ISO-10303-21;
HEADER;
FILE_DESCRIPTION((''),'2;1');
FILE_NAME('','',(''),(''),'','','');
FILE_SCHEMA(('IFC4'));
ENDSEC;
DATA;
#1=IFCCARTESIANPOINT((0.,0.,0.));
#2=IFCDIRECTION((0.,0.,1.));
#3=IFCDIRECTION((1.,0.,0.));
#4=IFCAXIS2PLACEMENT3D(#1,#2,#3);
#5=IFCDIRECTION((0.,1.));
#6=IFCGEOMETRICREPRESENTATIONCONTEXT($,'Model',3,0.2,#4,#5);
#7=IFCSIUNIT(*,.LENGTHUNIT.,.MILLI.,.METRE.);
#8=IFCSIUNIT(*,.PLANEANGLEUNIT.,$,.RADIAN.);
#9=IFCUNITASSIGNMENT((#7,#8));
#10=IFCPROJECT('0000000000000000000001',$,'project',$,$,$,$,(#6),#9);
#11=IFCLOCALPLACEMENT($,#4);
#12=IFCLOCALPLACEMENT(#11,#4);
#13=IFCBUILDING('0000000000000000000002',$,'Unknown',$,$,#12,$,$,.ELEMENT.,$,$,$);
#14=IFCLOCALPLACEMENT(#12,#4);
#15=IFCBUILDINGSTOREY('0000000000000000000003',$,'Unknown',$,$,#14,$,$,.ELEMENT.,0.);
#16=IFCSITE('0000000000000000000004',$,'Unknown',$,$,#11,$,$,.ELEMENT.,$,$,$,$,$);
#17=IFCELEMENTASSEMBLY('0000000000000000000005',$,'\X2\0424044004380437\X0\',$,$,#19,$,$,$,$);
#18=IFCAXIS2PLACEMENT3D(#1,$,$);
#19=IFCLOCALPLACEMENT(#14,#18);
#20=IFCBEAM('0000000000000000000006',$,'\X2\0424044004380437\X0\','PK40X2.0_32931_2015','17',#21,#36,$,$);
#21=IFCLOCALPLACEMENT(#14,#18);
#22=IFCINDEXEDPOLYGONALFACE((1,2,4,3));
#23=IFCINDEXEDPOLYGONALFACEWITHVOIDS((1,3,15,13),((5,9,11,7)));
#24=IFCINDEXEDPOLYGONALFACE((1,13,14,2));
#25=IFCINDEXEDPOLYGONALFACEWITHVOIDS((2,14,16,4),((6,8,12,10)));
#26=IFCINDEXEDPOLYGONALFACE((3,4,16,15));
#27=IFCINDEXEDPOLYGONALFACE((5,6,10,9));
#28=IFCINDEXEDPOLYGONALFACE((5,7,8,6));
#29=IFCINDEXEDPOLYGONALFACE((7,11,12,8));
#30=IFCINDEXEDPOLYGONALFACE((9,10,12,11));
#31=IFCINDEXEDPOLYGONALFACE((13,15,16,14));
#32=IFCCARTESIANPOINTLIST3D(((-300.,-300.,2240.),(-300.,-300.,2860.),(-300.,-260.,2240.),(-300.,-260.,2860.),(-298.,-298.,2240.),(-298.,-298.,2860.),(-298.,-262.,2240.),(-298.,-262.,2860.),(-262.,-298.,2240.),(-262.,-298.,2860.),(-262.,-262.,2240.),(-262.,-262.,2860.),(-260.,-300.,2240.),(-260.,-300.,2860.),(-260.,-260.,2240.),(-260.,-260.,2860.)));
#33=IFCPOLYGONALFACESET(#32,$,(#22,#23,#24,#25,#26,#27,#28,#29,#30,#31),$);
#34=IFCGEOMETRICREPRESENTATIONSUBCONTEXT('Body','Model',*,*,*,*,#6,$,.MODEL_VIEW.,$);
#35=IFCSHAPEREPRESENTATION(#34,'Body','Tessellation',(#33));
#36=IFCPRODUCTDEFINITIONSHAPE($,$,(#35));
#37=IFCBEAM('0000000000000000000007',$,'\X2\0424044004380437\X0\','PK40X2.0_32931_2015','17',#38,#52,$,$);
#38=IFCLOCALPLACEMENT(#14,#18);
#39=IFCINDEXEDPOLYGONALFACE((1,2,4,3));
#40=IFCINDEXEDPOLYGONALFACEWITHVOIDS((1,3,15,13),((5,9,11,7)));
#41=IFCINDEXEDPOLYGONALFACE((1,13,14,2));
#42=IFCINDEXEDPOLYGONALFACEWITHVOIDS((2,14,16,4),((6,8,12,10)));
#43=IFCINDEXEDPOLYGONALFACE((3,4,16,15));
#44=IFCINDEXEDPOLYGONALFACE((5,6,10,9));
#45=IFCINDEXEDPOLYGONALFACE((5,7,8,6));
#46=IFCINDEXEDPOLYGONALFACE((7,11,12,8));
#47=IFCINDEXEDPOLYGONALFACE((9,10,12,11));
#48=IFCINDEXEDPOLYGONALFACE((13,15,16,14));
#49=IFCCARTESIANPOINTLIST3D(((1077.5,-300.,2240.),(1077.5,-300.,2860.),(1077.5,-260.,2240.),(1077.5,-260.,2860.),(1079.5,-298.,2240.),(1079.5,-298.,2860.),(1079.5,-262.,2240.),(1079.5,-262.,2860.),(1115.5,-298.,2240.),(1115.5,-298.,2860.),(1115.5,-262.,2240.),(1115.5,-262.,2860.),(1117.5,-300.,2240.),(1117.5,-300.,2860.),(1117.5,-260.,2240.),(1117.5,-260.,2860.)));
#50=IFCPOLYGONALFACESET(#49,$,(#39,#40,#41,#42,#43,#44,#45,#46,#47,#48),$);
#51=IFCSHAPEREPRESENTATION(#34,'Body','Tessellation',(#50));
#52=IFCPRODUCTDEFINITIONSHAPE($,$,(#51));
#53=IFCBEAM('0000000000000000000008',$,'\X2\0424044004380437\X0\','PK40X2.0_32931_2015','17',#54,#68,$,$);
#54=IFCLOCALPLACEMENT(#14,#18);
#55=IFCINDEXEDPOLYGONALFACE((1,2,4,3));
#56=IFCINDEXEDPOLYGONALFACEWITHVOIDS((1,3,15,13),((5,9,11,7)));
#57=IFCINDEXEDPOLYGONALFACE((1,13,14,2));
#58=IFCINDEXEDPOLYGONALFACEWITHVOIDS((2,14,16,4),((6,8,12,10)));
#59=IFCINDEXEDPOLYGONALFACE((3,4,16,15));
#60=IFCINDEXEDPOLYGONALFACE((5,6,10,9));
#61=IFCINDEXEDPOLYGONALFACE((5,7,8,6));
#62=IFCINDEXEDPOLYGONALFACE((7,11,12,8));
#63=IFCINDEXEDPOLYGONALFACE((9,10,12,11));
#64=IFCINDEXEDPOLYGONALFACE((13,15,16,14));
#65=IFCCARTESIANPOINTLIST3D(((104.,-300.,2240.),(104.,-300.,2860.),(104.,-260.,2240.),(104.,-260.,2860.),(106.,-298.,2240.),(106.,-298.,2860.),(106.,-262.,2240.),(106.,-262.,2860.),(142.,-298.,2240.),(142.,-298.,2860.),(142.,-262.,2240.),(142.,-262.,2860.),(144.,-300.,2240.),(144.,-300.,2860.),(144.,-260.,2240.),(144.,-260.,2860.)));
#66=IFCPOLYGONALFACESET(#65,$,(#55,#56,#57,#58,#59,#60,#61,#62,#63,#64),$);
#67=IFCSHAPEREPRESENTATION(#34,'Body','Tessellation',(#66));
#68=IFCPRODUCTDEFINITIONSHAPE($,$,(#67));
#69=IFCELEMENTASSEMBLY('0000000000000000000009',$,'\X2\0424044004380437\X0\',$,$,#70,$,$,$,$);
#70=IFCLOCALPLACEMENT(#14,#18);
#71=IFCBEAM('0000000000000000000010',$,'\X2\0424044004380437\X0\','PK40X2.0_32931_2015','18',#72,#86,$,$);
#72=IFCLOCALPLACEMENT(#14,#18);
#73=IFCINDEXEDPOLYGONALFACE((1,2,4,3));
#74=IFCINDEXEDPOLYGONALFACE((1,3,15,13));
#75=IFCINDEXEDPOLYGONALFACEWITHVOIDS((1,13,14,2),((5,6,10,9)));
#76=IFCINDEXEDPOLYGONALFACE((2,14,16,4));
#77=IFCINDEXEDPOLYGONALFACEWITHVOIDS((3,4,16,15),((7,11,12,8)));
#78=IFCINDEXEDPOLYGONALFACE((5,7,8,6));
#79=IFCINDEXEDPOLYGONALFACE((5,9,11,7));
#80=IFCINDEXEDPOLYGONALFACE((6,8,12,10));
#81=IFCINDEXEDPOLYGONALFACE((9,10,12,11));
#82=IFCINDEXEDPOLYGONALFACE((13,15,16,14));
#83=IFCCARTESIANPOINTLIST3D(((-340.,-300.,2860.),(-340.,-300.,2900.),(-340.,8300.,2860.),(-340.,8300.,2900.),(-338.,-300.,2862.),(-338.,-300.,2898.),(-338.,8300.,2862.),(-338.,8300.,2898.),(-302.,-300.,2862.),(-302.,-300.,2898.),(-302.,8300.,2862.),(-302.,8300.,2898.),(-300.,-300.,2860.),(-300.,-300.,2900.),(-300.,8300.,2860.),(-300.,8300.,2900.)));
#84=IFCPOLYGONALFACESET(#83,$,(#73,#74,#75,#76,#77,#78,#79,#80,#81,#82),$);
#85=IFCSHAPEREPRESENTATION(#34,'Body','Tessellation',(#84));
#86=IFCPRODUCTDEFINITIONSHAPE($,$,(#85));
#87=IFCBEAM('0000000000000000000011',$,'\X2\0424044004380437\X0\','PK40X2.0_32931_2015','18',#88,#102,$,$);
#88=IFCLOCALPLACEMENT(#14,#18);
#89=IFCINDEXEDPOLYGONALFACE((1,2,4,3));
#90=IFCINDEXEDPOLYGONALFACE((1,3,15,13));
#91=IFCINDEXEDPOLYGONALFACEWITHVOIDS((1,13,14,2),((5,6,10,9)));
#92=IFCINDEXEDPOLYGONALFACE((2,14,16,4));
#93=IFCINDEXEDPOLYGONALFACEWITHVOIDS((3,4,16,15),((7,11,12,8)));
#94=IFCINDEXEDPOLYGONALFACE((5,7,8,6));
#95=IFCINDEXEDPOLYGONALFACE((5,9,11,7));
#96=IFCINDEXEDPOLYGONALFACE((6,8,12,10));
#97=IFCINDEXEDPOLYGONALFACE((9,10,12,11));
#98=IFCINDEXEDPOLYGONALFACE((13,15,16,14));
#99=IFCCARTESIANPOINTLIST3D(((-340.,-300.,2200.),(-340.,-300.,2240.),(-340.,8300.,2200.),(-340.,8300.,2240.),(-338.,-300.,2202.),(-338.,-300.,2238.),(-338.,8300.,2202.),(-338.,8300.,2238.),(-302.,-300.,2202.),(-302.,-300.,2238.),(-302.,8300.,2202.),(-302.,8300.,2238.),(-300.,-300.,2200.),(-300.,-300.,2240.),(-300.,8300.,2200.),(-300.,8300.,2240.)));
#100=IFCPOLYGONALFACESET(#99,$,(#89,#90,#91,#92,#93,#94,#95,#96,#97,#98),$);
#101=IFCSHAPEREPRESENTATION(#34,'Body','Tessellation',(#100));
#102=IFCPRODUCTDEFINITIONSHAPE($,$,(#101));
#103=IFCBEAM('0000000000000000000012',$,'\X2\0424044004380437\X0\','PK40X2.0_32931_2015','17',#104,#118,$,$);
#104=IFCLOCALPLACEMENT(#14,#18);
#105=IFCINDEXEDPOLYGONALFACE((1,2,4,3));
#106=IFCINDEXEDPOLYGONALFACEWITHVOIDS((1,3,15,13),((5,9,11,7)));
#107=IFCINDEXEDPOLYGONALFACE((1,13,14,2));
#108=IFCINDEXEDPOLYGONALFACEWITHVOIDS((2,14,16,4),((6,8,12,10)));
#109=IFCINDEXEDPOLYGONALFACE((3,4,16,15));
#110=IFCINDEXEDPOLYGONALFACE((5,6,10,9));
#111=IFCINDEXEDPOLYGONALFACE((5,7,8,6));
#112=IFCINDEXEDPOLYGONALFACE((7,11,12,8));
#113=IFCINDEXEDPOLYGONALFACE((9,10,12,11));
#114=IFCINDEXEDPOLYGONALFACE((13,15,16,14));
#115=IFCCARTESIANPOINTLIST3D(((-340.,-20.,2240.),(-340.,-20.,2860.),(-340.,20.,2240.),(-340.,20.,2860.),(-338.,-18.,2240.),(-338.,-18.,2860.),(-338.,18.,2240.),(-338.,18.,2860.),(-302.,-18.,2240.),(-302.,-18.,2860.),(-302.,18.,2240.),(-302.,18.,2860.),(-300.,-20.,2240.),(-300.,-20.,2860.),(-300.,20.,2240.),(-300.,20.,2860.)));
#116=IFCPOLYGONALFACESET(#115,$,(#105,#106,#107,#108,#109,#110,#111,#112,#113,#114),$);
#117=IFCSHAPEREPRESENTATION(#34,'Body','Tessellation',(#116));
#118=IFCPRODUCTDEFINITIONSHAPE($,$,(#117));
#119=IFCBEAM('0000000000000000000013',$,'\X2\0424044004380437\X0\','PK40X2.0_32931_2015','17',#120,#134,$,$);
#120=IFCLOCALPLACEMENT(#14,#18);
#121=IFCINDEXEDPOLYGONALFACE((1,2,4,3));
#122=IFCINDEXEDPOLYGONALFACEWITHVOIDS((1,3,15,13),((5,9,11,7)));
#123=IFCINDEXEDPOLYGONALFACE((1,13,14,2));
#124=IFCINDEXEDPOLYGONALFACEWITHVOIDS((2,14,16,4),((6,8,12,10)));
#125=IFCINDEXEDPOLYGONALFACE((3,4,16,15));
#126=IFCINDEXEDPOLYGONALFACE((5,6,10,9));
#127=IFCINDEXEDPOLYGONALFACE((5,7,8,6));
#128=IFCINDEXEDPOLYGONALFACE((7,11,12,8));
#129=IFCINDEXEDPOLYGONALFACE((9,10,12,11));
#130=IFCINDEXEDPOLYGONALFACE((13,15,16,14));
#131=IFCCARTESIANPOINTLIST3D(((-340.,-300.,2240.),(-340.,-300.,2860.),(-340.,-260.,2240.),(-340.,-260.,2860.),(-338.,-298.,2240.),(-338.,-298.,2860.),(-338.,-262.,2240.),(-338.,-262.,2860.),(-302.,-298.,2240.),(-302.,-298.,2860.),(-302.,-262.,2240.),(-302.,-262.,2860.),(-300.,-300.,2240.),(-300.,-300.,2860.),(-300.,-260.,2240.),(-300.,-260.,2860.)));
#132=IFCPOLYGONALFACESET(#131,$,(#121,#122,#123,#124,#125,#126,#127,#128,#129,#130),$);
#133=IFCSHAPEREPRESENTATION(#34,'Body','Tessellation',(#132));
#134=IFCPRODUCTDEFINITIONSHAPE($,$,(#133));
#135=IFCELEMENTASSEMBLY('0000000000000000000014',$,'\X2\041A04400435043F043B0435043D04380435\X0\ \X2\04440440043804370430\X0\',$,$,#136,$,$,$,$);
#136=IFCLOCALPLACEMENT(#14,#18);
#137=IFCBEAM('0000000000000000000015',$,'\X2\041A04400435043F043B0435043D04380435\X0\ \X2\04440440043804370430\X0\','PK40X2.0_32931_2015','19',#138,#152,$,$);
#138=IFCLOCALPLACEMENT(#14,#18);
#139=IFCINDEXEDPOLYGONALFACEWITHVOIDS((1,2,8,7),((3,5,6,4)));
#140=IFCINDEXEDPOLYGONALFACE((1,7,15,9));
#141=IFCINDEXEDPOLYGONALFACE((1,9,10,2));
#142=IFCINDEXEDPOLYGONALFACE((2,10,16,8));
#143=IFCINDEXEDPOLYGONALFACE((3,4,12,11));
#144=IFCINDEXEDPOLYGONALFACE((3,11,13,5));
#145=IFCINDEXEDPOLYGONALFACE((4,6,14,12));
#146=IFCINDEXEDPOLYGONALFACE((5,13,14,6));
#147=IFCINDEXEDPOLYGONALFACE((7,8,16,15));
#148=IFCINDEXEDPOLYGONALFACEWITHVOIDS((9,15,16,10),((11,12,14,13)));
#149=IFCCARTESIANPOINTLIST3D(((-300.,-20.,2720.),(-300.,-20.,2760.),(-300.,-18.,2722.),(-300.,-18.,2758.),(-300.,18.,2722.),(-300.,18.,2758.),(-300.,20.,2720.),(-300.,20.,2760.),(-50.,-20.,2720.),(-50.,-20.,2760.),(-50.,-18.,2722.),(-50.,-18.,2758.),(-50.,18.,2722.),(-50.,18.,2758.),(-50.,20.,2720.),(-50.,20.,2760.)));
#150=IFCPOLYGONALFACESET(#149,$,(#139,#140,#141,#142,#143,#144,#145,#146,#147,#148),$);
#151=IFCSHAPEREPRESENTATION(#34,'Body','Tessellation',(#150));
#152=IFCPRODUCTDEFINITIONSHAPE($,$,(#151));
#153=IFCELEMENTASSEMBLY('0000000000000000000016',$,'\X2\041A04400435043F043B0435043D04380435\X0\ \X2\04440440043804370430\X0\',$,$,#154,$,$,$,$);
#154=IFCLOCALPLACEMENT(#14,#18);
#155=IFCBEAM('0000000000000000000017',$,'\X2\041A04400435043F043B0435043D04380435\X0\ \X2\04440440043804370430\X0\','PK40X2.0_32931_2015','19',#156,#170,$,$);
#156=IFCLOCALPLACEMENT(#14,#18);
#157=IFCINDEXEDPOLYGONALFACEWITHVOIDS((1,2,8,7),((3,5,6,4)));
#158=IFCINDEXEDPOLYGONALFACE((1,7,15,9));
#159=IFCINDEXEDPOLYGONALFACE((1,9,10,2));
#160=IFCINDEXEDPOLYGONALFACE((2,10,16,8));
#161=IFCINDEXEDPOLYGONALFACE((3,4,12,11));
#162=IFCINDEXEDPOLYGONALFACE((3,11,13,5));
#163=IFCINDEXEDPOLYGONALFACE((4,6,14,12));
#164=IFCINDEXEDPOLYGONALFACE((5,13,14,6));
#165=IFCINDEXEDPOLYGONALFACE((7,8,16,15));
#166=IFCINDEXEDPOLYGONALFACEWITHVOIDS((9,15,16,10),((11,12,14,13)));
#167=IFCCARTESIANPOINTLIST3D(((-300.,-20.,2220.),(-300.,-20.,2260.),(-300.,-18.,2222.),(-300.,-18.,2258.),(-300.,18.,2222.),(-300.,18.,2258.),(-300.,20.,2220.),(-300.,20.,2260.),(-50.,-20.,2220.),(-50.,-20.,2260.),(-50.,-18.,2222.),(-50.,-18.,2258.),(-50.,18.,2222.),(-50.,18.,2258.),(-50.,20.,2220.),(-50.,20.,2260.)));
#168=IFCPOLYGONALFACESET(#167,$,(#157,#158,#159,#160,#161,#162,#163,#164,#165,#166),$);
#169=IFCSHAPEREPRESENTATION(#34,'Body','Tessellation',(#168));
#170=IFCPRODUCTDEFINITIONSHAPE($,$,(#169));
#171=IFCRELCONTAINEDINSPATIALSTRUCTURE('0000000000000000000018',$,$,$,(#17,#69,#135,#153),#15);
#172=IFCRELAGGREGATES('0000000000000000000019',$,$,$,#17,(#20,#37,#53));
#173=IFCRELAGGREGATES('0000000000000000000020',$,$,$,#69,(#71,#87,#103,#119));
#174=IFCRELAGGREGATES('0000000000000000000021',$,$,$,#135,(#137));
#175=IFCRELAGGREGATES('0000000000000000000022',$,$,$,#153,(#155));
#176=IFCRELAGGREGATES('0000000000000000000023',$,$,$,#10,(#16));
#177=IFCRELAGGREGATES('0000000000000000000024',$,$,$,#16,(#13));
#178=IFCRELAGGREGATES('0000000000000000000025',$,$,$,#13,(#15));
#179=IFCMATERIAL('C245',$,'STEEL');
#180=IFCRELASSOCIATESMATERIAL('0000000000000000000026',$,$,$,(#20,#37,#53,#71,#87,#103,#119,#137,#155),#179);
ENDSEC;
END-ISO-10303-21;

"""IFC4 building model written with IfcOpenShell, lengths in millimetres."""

from ifc_helpers import new_model, si_unit, direction, frame, origin_with_axes, place, context, subcontext, project, spatial, line, indexed_curve, outline, extrude, material, element, aggregate, save


model = new_model("IFC4")

# Units and contexts
model_context = context("Model", 3, precision=0.2, world=origin_with_axes(), true_north=direction((0.0, 1.0)))
body_context = subcontext(model_context, "Body", "Model", "MODEL_VIEW")
ifc_project = project(units=[si_unit("LENGTHUNIT", "METRE", prefix="MILLI"), si_unit("PLANEANGLEUNIT", "RADIAN")], contexts=[model_context])

# Site, building, storey
site_placement = place(None, origin_with_axes())
site = spatial("IfcSite", under=ifc_project, at=site_placement, Name="Unknown", CompositionType="ELEMENT")
building_placement = place(site_placement, origin_with_axes())
building = spatial("IfcBuilding", under=site, at=building_placement, Name="Unknown", CompositionType="ELEMENT")
storey_placement = place(building_placement, origin_with_axes())
storey = spatial("IfcBuildingStorey", under=building, at=storey_placement, Name="Unknown", CompositionType="ELEMENT", Elevation=0.0)

# Shared definitions
ifc_material_1 = material(Name="C245", Category="STEEL")

# Element assemblies, beams
assembly_1_placement = place(storey_placement, frame((-300.0, -280.0, 2880.0), z_axis=(0.0, -1.0, 0.0), x_axis=(1.0, 0.0, 0.0)))
assembly_1 = element("IfcElementAssembly", 1, at=assembly_1_placement, inside=storey, Name="Фриз")
beam_1_placement = place(assembly_1_placement, frame((20.0, -20.0, 0.0), z_axis=(0.0, 0.0, -1.0), x_axis=(0.0, -1.0, 0.0)))
beam_1 = element("IfcBeam", 2, at=beam_1_placement, material=ifc_material_1, Name="Фриз", Description="PK40X2.0_32931_2015", ObjectType="17", context=body_context, shape_type="SolidModel", body=[
    extrude(outline(indexed_curve([(-20.0, -20.0), (20.0, -20.0), (20.0, 20.0), (-20.0, 20.0)], segments=[line(1, 2, 3, 4, 1)]), holes=[indexed_curve([(-18.0, -18.0), (-18.0, 18.0), (18.0, 18.0), (18.0, -18.0)], segments=[line(1, 2, 3, 4, 1)])]), frame((0.0, 0.0, 0.0), z_axis=(-1.0, 0.0, 0.0), x_axis=(0.0, 0.0, 1.0)), (0.0, 0.0, -1.0), 620.0),
])
beam_2_placement = place(assembly_1_placement, frame((1397.5, -20.0, 0.0), z_axis=(0.0, 0.0, 1.0), x_axis=(0.0, -1.0, 0.0)))
beam_2 = element("IfcBeam", 3, at=beam_2_placement, material=ifc_material_1, Name="Фриз", Description="PK40X2.0_32931_2015", ObjectType="17", context=body_context, shape_type="SolidModel", body=[
    extrude(outline(indexed_curve([(-20.0, -20.0), (20.0, -20.0), (20.0, 20.0), (-20.0, 20.0)], segments=[line(1, 2, 3, 4, 1)]), holes=[indexed_curve([(-18.0, -18.0), (-18.0, 18.0), (18.0, 18.0), (18.0, -18.0)], segments=[line(1, 2, 3, 4, 1)])]), frame((0.0, 0.0, 0.0), z_axis=(-1.0, 0.0, 0.0), x_axis=(0.0, 0.0, 1.0)), (0.0, 0.0, -1.0), 620.0),
])
beam_3_placement = place(assembly_1_placement, frame((424.0, -20.0, 0.0), z_axis=(0.0, 0.0, 1.0), x_axis=(0.0, -1.0, 0.0)))
beam_3 = element("IfcBeam", 4, at=beam_3_placement, material=ifc_material_1, Name="Фриз", Description="PK40X2.0_32931_2015", ObjectType="17", context=body_context, shape_type="SolidModel", body=[
    extrude(outline(indexed_curve([(-20.0, -20.0), (20.0, -20.0), (20.0, 20.0), (-20.0, 20.0)], segments=[line(1, 2, 3, 4, 1)]), holes=[indexed_curve([(-18.0, -18.0), (-18.0, 18.0), (18.0, 18.0), (18.0, -18.0)], segments=[line(1, 2, 3, 4, 1)])]), frame((0.0, 0.0, 0.0), z_axis=(-1.0, 0.0, 0.0), x_axis=(0.0, 0.0, 1.0)), (0.0, 0.0, -1.0), 620.0),
])
aggregate(assembly_1, [beam_1, beam_2, beam_3])
assembly_2_placement = place(storey_placement, frame((-320.0, -300.0, 2880.0), z_axis=(1.0, 0.0, 0.0), x_axis=(0.0, 1.0, 0.0)))
assembly_2 = element("IfcElementAssembly", 5, at=assembly_2_placement, inside=storey, Name="Фриз")
beam_4_placement = place(assembly_2_placement, origin_with_axes())
beam_4 = element("IfcBeam", 6, at=beam_4_placement, material=ifc_material_1, Name="Фриз", Description="PK40X2.0_32931_2015", ObjectType="18", context=body_context, shape_type="SolidModel", body=[
    extrude(outline(indexed_curve([(-20.0, -20.0), (20.0, -20.0), (20.0, 20.0), (-20.0, 20.0)], segments=[line(1, 2, 3, 4, 1)]), holes=[indexed_curve([(-18.0, -18.0), (-18.0, 18.0), (18.0, 18.0), (18.0, -18.0)], segments=[line(1, 2, 3, 4, 1)])]), frame((0.0, 0.0, 0.0), z_axis=(-1.0, 0.0, 0.0), x_axis=(0.0, 0.0, 1.0)), (0.0, 0.0, -1.0), 8600.0),
])
beam_5_placement = place(assembly_2_placement, frame((0.0, -660.0, 0.0), z_axis=(0.0, 0.0, 1.0), x_axis=(1.0, 0.0, 0.0)))
beam_5 = element("IfcBeam", 7, at=beam_5_placement, material=ifc_material_1, Name="Фриз", Description="PK40X2.0_32931_2015", ObjectType="18", context=body_context, shape_type="SolidModel", body=[
    extrude(outline(indexed_curve([(-20.0, -20.0), (20.0, -20.0), (20.0, 20.0), (-20.0, 20.0)], segments=[line(1, 2, 3, 4, 1)]), holes=[indexed_curve([(-18.0, -18.0), (-18.0, 18.0), (18.0, 18.0), (18.0, -18.0)], segments=[line(1, 2, 3, 4, 1)])]), frame((0.0, 0.0, 0.0), z_axis=(-1.0, 0.0, 0.0), x_axis=(0.0, 0.0, 1.0)), (0.0, 0.0, -1.0), 8600.0),
])
beam_6_placement = place(assembly_2_placement, frame((300.0, -20.0, 0.0), z_axis=(-1.0, 0.0, 0.0), x_axis=(0.0, -1.0, 0.0)))
beam_6 = element("IfcBeam", 8, at=beam_6_placement, material=ifc_material_1, Name="Фриз", Description="PK40X2.0_32931_2015", ObjectType="17", context=body_context, shape_type="SolidModel", body=[
    extrude(outline(indexed_curve([(-20.0, -20.0), (20.0, -20.0), (20.0, 20.0), (-20.0, 20.0)], segments=[line(1, 2, 3, 4, 1)]), holes=[indexed_curve([(-18.0, -18.0), (-18.0, 18.0), (18.0, 18.0), (18.0, -18.0)], segments=[line(1, 2, 3, 4, 1)])]), frame((0.0, 0.0, 0.0), z_axis=(-1.0, 0.0, 0.0), x_axis=(0.0, 0.0, 1.0)), (0.0, 0.0, -1.0), 620.0),
])
beam_7_placement = place(assembly_2_placement, frame((20.0, -20.0, 0.0), z_axis=(-1.0, 0.0, 0.0), x_axis=(0.0, -1.0, 0.0)))
beam_7 = element("IfcBeam", 9, at=beam_7_placement, material=ifc_material_1, Name="Фриз", Description="PK40X2.0_32931_2015", ObjectType="17", context=body_context, shape_type="SolidModel", body=[
    extrude(outline(indexed_curve([(-20.0, -20.0), (20.0, -20.0), (20.0, 20.0), (-20.0, 20.0)], segments=[line(1, 2, 3, 4, 1)]), holes=[indexed_curve([(-18.0, -18.0), (-18.0, 18.0), (18.0, 18.0), (18.0, -18.0)], segments=[line(1, 2, 3, 4, 1)])]), frame((0.0, 0.0, 0.0), z_axis=(-1.0, 0.0, 0.0), x_axis=(0.0, 0.0, 1.0)), (0.0, 0.0, -1.0), 620.0),
])
aggregate(assembly_2, [beam_4, beam_5, beam_6, beam_7])

# Element assemblies, beams
assembly_3_placement = place(storey_placement, frame((-300.0, 0.0, 2740.0), z_axis=(0.0, 1.0, 0.0), x_axis=(1.0, 0.0, 0.0)))
assembly_3 = element("IfcElementAssembly", 10, at=assembly_3_placement, inside=storey, Name="Крепление фриза")
beam_8_placement = place(assembly_3_placement, origin_with_axes())
beam_8 = element("IfcBeam", 11, at=beam_8_placement, material=ifc_material_1, Name="Крепление фриза", Description="PK40X2.0_32931_2015", ObjectType="19", context=body_context, shape_type="SolidModel", body=[
    extrude(outline(indexed_curve([(-20.0, -20.0), (20.0, -20.0), (20.0, 20.0), (-20.0, 20.0)], segments=[line(1, 2, 3, 4, 1)]), holes=[indexed_curve([(-18.0, -18.0), (-18.0, 18.0), (18.0, 18.0), (18.0, -18.0)], segments=[line(1, 2, 3, 4, 1)])]), frame((0.0, 0.0, 0.0), z_axis=(-1.0, 0.0, 0.0), x_axis=(0.0, 0.0, 1.0)), (0.0, 0.0, -1.0), 250.0),
])
aggregate(assembly_3, [beam_8])
assembly_4_placement = place(storey_placement, frame((-300.0, 0.0, 2240.0), z_axis=(0.0, 1.0, 0.0), x_axis=(1.0, 0.0, 0.0)))
assembly_4 = element("IfcElementAssembly", 12, at=assembly_4_placement, inside=storey, Name="Крепление фриза")
beam_9_placement = place(assembly_4_placement, origin_with_axes())
beam_9 = element("IfcBeam", 13, at=beam_9_placement, material=ifc_material_1, Name="Крепление фриза", Description="PK40X2.0_32931_2015", ObjectType="19", context=body_context, shape_type="SolidModel", body=[
    extrude(outline(indexed_curve([(-20.0, -20.0), (20.0, -20.0), (20.0, 20.0), (-20.0, 20.0)], segments=[line(1, 2, 3, 4, 1)]), holes=[indexed_curve([(-18.0, -18.0), (-18.0, 18.0), (18.0, 18.0), (18.0, -18.0)], segments=[line(1, 2, 3, 4, 1)])]), frame((0.0, 0.0, 0.0), z_axis=(-1.0, 0.0, 0.0), x_axis=(0.0, 0.0, 1.0)), (0.0, 0.0, -1.0), 250.0),
])
aggregate(assembly_4, [beam_9])

save(model, "model.ifc")
